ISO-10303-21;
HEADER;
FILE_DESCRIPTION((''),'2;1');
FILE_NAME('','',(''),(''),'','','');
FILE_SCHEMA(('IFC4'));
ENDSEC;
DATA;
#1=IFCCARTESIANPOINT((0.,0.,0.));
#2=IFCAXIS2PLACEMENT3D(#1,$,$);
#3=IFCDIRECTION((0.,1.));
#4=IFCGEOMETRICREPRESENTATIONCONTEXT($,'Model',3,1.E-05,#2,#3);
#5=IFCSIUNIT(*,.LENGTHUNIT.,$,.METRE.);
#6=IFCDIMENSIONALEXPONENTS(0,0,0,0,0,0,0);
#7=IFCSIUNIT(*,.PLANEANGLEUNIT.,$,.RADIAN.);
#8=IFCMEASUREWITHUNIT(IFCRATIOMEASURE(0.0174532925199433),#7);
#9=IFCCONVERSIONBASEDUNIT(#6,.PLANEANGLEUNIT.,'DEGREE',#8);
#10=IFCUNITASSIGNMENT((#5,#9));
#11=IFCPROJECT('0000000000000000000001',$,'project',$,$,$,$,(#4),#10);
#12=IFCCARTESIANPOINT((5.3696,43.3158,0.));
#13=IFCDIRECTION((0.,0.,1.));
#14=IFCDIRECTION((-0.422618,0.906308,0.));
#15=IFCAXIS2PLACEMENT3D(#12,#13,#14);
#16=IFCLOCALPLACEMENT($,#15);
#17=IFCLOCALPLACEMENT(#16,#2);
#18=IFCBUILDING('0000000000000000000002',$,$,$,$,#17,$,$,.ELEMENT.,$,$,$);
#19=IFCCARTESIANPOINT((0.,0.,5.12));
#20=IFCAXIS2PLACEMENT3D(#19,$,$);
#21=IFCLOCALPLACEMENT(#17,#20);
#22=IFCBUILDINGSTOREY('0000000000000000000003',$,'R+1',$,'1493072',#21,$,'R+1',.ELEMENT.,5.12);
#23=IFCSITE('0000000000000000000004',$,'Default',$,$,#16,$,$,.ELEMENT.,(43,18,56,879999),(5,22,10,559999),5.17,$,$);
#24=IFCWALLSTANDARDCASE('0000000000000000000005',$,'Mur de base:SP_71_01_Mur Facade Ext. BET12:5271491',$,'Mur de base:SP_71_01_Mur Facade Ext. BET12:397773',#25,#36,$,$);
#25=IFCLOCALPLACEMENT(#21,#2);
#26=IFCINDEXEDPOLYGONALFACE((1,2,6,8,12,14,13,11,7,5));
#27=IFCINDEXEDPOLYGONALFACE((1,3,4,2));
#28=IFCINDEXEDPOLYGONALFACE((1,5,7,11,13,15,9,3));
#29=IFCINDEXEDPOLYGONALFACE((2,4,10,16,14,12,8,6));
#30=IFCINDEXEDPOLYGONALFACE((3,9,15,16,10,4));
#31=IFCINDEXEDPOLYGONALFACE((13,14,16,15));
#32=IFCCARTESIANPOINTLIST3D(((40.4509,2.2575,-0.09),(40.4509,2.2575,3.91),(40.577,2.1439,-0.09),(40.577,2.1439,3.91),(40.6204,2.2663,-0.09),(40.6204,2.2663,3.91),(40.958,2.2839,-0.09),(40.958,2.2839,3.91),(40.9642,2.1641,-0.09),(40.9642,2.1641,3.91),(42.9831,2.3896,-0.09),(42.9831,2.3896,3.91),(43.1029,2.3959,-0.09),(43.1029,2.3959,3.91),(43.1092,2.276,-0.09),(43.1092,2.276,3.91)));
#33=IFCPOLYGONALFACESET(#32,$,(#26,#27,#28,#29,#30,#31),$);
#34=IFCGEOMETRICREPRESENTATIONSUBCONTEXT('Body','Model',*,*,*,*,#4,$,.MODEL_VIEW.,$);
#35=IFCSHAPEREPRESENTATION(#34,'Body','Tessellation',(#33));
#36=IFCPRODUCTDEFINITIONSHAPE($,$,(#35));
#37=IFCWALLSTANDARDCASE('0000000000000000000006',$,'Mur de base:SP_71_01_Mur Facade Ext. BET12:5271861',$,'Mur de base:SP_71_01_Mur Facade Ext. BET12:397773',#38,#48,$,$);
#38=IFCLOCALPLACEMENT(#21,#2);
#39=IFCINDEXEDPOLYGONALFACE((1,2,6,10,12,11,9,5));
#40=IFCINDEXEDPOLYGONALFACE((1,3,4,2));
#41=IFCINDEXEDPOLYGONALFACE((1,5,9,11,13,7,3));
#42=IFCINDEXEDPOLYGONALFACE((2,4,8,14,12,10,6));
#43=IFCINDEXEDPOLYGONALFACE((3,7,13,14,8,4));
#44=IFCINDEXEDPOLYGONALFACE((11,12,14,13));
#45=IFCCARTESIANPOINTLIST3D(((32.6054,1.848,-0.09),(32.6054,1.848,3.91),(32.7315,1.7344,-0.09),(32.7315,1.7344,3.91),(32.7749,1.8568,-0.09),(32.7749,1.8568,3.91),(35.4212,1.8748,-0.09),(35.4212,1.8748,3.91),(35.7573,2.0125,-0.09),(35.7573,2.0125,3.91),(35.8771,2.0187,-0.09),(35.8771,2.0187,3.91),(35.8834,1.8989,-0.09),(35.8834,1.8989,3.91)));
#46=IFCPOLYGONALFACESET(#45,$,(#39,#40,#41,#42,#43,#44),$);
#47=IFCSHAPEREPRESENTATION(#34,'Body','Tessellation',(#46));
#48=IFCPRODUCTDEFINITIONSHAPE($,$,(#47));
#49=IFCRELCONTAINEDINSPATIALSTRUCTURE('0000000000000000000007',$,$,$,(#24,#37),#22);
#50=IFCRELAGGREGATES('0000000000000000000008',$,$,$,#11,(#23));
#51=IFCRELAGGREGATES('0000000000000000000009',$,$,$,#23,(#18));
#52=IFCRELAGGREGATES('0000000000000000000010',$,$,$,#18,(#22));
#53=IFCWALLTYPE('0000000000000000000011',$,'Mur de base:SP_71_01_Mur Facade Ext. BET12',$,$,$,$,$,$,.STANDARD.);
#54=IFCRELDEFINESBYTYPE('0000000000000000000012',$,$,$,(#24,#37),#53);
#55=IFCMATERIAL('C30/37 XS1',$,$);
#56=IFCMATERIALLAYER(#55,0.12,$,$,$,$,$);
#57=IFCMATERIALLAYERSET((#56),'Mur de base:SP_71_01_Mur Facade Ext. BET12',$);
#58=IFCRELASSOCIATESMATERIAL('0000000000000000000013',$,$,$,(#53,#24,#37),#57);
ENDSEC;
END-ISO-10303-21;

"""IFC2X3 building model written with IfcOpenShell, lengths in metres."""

from ifc_helpers import new_model, entity, si_unit, converted_unit, direction, frame, origin, place, context, subcontext, project, spatial, polyline, outline, extrude, material, layer, layer_set, layer_usage, type_object, element, save


model = new_model("IFC2X3")

# Units and contexts
model_context = context("Model", 3, precision=1e-05, world=origin(), true_north=direction((0.0, 1.0)))
body_context = subcontext(model_context, "Body", "Model", "MODEL_VIEW")
ifc_project = project(units=[si_unit("LENGTHUNIT", "METRE"), converted_unit("PLANEANGLEUNIT", "DEGREE", entity("IfcRatioMeasure", 0.0174532925199433), si_unit("PLANEANGLEUNIT", "RADIAN"), dimensions=[0, 0, 0, 0, 0, 0, 0])], contexts=[model_context])

# Site, building, storey
site_placement = place(None, frame((5.3696, 43.3158, 0.0), z_axis=(0.0, 0.0, 1.0), x_axis=(-0.422618, 0.906308, 0.0)))
site = spatial("IfcSite", under=ifc_project, at=site_placement, Name="Default", CompositionType="ELEMENT", RefLatitude=(43, 18, 56, 879999), RefLongitude=(5, 22, 10, 559999), RefElevation=5.17)
building_placement = place(site_placement, origin())
building = spatial("IfcBuilding", under=site, at=building_placement, CompositionType="ELEMENT")
storey_placement = place(building_placement, frame((0.0, 0.0, 5.12)))
storey = spatial("IfcBuildingStorey", under=building, at=storey_placement, Name="R+1", ObjectType="1493072", LongName="R+1", CompositionType="ELEMENT", Elevation=5.12)

# Shared definitions
ifc_material_1 = material(Name="C30/37 XS1")

# Shared definitions
ifc_layer_1 = layer(ifc_material_1, 0.12)
ifc_layer_set_1 = layer_set([ifc_layer_1], Name="Mur de base:SP_71_01_Mur Facade Ext. BET12")
wall_type_1 = type_object("IfcWallType", Name="Mur de base:SP_71_01_Mur Facade Ext. BET12", PredefinedType="STANDARD", material=ifc_layer_set_1)

# Walls
ifc_layer_usage_1 = layer_usage(ifc_layer_set_1, "AXIS2", "NEGATIVE", 0.06)
wall_1_placement = place(storey_placement, frame((43.106, 2.3359, -0.09), z_axis=(0.0, 0.0, 1.0), x_axis=(-0.998641, -0.05212, 0.0)))
element("IfcWallStandardCase", 1, at=wall_1_placement, inside=storey, type_object=wall_type_1, material=ifc_layer_usage_1, Name="Mur de base:SP_71_01_Mur Facade Ext. BET12:5271491", ObjectType="Mur de base:SP_71_01_Mur Facade Ext. BET12:397773", context=body_context, shape_type="SweptSolid", body=[
    extrude(outline(polyline([(2.6556, -0.06), (2.5356, 0.06), (2.1478, 0.06), (0.0, 0.06), (0.0, -0.06), (0.12, -0.06), (2.1478, -0.06), (2.4859, -0.06), (2.6556, -0.06)])), origin(), (0.0, 0.0, 1.0), 4.0),
])
ifc_layer_usage_2 = layer_usage(ifc_layer_set_1, "AXIS2", "NEGATIVE", 0.06)
wall_2_placement = place(storey_placement, frame((35.8802, 1.9588, -0.09), z_axis=(0.0, 0.0, 1.0), x_axis=(-0.998641, -0.05212, 0.0)))
element("IfcWallStandardCase", 2, at=wall_2_placement, inside=storey, type_object=wall_type_1, material=ifc_layer_usage_2, Name="Mur de base:SP_71_01_Mur Facade Ext. BET12:5271861", ObjectType="Mur de base:SP_71_01_Mur Facade Ext. BET12:397773", context=body_context, shape_type="SweptSolid", body=[
    extrude(outline(polyline([(3.2762, -0.06), (3.1562, 0.06), (0.4628, 0.06), (0.0, 0.06), (0.0, -0.06), (0.12, -0.06), (3.1065, -0.06), (3.2762, -0.06)])), origin(), (0.0, 0.0, 1.0), 4.0),
])

save(model, "model.ifc")
